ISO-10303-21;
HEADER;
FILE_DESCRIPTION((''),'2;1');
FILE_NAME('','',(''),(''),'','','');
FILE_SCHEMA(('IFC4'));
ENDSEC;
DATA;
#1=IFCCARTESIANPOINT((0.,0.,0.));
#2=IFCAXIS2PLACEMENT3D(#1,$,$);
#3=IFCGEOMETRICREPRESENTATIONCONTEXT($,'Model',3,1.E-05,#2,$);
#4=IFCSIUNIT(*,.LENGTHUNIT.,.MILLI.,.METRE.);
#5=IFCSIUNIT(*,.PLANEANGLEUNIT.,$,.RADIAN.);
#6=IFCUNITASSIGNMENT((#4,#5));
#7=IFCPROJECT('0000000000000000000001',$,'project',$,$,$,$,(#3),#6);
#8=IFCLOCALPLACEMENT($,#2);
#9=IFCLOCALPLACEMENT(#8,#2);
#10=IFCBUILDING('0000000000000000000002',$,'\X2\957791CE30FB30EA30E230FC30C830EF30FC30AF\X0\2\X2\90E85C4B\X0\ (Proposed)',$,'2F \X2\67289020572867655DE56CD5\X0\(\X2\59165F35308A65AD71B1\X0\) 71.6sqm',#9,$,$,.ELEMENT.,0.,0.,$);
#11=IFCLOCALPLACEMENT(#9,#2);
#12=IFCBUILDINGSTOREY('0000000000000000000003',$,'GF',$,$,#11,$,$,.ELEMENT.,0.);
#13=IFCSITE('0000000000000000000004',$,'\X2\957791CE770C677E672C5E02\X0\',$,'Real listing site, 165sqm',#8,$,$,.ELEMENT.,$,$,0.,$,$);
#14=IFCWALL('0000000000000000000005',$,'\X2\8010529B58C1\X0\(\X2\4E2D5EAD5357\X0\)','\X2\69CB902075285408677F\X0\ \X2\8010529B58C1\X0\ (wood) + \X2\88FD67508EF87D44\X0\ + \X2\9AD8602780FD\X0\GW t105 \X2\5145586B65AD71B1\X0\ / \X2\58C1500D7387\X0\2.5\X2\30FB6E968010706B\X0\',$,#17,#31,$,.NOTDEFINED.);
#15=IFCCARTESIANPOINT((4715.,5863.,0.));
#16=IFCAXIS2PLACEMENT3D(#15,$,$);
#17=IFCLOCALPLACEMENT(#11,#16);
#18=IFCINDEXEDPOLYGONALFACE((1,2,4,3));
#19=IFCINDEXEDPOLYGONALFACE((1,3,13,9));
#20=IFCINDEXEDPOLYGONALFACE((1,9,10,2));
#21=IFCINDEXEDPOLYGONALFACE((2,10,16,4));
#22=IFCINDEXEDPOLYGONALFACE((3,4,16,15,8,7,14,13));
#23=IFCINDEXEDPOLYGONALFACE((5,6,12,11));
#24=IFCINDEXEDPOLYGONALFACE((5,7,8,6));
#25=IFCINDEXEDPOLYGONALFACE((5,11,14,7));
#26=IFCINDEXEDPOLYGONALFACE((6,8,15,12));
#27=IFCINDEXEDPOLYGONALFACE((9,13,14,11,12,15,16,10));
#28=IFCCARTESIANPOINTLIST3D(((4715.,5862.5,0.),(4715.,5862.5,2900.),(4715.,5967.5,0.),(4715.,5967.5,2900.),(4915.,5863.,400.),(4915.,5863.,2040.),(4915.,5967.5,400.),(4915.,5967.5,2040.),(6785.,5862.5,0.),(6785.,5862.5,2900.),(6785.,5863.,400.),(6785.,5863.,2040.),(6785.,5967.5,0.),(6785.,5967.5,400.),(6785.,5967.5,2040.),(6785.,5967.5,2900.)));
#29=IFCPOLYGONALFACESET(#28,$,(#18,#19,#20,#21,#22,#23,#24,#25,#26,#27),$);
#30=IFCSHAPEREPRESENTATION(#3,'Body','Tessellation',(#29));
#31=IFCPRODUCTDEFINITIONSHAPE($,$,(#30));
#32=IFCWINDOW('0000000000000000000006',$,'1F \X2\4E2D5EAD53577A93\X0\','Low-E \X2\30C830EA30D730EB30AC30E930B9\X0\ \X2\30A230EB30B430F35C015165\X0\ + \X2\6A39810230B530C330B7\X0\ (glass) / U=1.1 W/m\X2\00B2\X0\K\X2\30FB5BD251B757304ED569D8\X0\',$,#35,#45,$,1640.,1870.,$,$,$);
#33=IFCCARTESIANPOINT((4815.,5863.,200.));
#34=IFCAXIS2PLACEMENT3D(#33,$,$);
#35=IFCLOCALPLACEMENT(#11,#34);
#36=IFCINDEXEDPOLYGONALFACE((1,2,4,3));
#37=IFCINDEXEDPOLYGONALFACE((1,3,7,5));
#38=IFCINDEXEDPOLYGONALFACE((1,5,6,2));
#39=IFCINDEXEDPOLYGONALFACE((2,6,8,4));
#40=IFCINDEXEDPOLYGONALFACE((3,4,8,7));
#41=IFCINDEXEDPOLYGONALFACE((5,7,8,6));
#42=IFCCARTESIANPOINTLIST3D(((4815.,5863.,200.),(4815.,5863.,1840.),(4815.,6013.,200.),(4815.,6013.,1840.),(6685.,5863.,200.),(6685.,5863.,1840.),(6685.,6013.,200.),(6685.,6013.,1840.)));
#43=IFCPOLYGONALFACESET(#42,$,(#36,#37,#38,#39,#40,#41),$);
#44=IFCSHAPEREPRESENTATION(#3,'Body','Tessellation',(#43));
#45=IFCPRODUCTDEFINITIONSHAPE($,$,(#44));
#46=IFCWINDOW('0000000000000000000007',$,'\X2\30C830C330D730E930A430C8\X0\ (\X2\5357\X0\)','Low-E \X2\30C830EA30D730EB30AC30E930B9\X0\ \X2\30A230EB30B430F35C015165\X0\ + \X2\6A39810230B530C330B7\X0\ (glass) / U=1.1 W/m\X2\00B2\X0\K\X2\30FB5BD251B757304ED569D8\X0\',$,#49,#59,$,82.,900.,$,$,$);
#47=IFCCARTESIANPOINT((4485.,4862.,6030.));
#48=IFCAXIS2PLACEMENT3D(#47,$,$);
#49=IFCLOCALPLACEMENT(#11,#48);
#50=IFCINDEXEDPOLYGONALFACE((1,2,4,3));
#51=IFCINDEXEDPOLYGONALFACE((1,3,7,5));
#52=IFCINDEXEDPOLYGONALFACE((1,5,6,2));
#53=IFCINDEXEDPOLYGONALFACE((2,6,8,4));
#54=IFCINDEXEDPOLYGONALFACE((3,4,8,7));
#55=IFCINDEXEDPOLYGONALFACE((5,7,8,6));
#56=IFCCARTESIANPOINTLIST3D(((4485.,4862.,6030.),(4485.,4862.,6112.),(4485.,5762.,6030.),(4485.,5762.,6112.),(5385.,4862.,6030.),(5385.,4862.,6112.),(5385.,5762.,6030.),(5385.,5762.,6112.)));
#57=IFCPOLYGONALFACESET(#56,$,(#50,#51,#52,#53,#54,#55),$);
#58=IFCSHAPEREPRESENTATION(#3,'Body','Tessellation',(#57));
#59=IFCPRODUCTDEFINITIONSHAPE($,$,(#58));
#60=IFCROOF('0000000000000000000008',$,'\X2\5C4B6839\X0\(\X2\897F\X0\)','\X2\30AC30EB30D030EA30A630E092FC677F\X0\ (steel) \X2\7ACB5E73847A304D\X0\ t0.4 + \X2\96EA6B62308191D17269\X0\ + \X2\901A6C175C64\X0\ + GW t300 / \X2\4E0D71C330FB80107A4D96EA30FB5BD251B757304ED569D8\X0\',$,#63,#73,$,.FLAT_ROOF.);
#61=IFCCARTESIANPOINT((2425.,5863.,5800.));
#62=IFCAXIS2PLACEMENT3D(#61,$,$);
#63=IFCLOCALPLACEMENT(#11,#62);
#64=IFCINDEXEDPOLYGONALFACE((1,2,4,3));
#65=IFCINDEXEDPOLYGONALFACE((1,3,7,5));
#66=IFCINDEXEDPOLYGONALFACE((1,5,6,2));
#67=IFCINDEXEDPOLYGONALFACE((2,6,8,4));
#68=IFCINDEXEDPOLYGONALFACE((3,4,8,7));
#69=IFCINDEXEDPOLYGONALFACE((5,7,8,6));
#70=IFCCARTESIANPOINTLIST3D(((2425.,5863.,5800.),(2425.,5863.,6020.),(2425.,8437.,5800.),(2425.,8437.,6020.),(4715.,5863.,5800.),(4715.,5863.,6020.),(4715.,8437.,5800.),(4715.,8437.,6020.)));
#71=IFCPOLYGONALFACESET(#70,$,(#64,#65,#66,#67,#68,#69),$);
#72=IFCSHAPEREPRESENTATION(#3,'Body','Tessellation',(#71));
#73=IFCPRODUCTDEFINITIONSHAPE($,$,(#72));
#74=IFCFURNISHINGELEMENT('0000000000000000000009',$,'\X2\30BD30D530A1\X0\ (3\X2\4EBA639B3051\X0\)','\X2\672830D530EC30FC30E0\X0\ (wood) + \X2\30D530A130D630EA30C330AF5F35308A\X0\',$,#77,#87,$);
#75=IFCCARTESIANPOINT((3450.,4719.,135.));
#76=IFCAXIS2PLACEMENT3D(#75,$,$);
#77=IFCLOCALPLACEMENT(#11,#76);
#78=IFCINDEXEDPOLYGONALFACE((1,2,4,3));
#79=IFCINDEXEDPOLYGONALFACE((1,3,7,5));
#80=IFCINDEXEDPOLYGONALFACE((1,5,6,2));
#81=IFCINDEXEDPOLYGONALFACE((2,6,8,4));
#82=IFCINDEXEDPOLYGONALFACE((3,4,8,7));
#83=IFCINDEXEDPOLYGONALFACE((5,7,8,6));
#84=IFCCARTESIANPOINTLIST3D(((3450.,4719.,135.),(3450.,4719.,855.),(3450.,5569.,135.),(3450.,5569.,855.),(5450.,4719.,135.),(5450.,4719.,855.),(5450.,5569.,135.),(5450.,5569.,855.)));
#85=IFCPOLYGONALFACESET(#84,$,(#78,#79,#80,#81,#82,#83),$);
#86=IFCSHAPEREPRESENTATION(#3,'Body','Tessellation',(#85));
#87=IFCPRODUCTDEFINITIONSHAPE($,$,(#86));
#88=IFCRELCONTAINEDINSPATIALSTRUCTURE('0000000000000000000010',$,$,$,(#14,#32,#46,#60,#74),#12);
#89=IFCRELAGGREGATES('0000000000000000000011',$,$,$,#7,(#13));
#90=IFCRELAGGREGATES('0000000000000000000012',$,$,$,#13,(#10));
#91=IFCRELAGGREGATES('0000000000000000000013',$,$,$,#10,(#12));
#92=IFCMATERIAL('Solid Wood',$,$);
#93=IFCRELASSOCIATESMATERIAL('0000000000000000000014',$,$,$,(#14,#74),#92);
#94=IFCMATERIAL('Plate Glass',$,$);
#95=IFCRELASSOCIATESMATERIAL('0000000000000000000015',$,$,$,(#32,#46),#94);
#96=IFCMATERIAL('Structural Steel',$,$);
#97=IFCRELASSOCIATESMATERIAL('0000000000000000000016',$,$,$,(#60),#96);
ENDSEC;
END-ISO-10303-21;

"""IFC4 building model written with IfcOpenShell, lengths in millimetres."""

from ifc_helpers import new_model, si_unit, frame, frame_2d, origin, place, context, project, spatial, rectangle, extrude, material, element, fill, save


model = new_model("IFC4")

# Units and contexts
model_context = context("Model", 3, precision=1e-05, world=origin())
ifc_project = project(units=[si_unit("LENGTHUNIT", "METRE", prefix="MILLI"), si_unit("PLANEANGLEUNIT", "RADIAN")], contexts=[model_context])

# Site, building, storey
site_placement = place(None, origin())
site = spatial("IfcSite", under=ifc_project, at=site_placement, Name="長野県松本市", ObjectType="Real listing site, 165sqm", CompositionType="ELEMENT", RefElevation=0.0)
building_placement = place(site_placement, origin())
building = spatial("IfcBuilding", under=site, at=building_placement, Name="長野・リモートワーク2部屋 (Proposed)", ObjectType="2F 木造在来工法(外張り断熱) 71.6sqm", CompositionType="ELEMENT", ElevationOfRefHeight=0.0, ElevationOfTerrain=0.0)
storey_placement = place(building_placement, origin())
storey = spatial("IfcBuildingStorey", under=building, at=storey_placement, Name="GF", CompositionType="ELEMENT", Elevation=0.0)

# Shared definitions
ifc_material_1 = material(Name="Solid Wood")

# Wall, opening, window
wall_placement = place(storey_placement, frame((4715.0, 5863.0, 0.0)))
wall = element("IfcWall", 1, at=wall_placement, inside=storey, material=ifc_material_1, Name="耐力壁(中庭南)", Description="構造用合板 耐力壁 (wood) + 製材軸組 + 高性能GW t105 充填断熱 / 壁倍率2.5・準耐火", PredefinedType="NOTDEFINED", context=model_context, shape_type="SweptSolid", body=[
    extrude(rectangle(XDim=2070.0, YDim=105.0, at=frame_2d((1035.0, 52.0))), frame((4715.0, 5863.0, 0.0)), (0.0, 0.0, 1.0), 2900.0),
])
opening_placement = place(storey_placement, frame((4815.0, 5863.0, 200.0)))
opening = element("IfcOpeningElement", 2, at=opening_placement, cuts=wall, PredefinedType="NOTDEFINED", context=model_context, shape_type="SweptSolid", body=[
    extrude(rectangle(XDim=1870.0, YDim=150.0, at=frame_2d((935.0, 75.0))), frame((4815.0, 5863.0, 200.0)), (0.0, 0.0, 1.0), 1640.0),
])
ifc_material_2 = material(Name="Plate Glass")
window_1_placement = place(storey_placement, frame((4815.0, 5863.0, 200.0)))
window_1 = element("IfcWindow", 3, at=window_1_placement, inside=storey, material=ifc_material_2, Name="1F 中庭南窓", Description="Low-E トリプルガラス アルゴン封入 + 樹脂サッシ (glass) / U=1.1 W/m²K・寒冷地仕様", OverallHeight=1640.0, OverallWidth=1870.0, context=model_context, shape_type="SweptSolid", body=[
    extrude(rectangle(XDim=1870.0, YDim=150.0, at=frame_2d((935.0, 75.0))), frame((4815.0, 5863.0, 200.0)), (0.0, 0.0, 1.0), 1640.0),
])
fill(opening, window_1)

# Window
window_2_placement = place(storey_placement, frame((4485.0, 4862.0, 6030.0)))
element("IfcWindow", 4, at=window_2_placement, inside=storey, material=ifc_material_2, Name="トップライト (南)", Description="Low-E トリプルガラス アルゴン封入 + 樹脂サッシ (glass) / U=1.1 W/m²K・寒冷地仕様", OverallHeight=82.0, OverallWidth=900.0, context=model_context, shape_type="SweptSolid", body=[
    extrude(rectangle(XDim=900.0, YDim=900.0, at=frame_2d((450.0, 450.0))), frame((4485.0, 4862.0, 6030.0)), (0.0, 0.0, 1.0), 82.0),
])

# Roof
ifc_material_3 = material(Name="Structural Steel")
for number, where, name in (
    (5, (2425.0, 5863.0, 5800.0), "屋根(西)"),
):
    element("IfcRoof", number, at=place(storey_placement, frame(where)), inside=storey, material=ifc_material_3, Name=name, Description="ガルバリウム鋼板 (steel) 立平葺き t0.4 + 雪止め金物 + 通気層 + GW t300 / 不燃・耐積雪・寒冷地仕様", PredefinedType="FLAT_ROOF", context=model_context, shape_type="SweptSolid", body=[
        extrude(rectangle(XDim=2290.0, YDim=2574.0, at=frame_2d((1145.0, 1287.0))), frame((2425.0, 5863.0, 5800.0)), (0.0, 0.0, 1.0), 220.0),
    ])

# Furnishing element
furnishing_placement = place(storey_placement, frame((3450.0, 4719.0, 135.0)))
element("IfcFurnishingElement", 6, at=furnishing_placement, inside=storey, material=ifc_material_1, Name="ソファ (3人掛け)", Description="木フレーム (wood) + ファブリック張り", context=model_context, shape_type="SweptSolid", body=[
    extrude(rectangle(XDim=2000.0, YDim=850.0, at=frame_2d((1000.0, 425.0))), frame((3450.0, 4719.0, 135.0)), (0.0, 0.0, 1.0), 720.0),
])

save(model, "model.ifc")
